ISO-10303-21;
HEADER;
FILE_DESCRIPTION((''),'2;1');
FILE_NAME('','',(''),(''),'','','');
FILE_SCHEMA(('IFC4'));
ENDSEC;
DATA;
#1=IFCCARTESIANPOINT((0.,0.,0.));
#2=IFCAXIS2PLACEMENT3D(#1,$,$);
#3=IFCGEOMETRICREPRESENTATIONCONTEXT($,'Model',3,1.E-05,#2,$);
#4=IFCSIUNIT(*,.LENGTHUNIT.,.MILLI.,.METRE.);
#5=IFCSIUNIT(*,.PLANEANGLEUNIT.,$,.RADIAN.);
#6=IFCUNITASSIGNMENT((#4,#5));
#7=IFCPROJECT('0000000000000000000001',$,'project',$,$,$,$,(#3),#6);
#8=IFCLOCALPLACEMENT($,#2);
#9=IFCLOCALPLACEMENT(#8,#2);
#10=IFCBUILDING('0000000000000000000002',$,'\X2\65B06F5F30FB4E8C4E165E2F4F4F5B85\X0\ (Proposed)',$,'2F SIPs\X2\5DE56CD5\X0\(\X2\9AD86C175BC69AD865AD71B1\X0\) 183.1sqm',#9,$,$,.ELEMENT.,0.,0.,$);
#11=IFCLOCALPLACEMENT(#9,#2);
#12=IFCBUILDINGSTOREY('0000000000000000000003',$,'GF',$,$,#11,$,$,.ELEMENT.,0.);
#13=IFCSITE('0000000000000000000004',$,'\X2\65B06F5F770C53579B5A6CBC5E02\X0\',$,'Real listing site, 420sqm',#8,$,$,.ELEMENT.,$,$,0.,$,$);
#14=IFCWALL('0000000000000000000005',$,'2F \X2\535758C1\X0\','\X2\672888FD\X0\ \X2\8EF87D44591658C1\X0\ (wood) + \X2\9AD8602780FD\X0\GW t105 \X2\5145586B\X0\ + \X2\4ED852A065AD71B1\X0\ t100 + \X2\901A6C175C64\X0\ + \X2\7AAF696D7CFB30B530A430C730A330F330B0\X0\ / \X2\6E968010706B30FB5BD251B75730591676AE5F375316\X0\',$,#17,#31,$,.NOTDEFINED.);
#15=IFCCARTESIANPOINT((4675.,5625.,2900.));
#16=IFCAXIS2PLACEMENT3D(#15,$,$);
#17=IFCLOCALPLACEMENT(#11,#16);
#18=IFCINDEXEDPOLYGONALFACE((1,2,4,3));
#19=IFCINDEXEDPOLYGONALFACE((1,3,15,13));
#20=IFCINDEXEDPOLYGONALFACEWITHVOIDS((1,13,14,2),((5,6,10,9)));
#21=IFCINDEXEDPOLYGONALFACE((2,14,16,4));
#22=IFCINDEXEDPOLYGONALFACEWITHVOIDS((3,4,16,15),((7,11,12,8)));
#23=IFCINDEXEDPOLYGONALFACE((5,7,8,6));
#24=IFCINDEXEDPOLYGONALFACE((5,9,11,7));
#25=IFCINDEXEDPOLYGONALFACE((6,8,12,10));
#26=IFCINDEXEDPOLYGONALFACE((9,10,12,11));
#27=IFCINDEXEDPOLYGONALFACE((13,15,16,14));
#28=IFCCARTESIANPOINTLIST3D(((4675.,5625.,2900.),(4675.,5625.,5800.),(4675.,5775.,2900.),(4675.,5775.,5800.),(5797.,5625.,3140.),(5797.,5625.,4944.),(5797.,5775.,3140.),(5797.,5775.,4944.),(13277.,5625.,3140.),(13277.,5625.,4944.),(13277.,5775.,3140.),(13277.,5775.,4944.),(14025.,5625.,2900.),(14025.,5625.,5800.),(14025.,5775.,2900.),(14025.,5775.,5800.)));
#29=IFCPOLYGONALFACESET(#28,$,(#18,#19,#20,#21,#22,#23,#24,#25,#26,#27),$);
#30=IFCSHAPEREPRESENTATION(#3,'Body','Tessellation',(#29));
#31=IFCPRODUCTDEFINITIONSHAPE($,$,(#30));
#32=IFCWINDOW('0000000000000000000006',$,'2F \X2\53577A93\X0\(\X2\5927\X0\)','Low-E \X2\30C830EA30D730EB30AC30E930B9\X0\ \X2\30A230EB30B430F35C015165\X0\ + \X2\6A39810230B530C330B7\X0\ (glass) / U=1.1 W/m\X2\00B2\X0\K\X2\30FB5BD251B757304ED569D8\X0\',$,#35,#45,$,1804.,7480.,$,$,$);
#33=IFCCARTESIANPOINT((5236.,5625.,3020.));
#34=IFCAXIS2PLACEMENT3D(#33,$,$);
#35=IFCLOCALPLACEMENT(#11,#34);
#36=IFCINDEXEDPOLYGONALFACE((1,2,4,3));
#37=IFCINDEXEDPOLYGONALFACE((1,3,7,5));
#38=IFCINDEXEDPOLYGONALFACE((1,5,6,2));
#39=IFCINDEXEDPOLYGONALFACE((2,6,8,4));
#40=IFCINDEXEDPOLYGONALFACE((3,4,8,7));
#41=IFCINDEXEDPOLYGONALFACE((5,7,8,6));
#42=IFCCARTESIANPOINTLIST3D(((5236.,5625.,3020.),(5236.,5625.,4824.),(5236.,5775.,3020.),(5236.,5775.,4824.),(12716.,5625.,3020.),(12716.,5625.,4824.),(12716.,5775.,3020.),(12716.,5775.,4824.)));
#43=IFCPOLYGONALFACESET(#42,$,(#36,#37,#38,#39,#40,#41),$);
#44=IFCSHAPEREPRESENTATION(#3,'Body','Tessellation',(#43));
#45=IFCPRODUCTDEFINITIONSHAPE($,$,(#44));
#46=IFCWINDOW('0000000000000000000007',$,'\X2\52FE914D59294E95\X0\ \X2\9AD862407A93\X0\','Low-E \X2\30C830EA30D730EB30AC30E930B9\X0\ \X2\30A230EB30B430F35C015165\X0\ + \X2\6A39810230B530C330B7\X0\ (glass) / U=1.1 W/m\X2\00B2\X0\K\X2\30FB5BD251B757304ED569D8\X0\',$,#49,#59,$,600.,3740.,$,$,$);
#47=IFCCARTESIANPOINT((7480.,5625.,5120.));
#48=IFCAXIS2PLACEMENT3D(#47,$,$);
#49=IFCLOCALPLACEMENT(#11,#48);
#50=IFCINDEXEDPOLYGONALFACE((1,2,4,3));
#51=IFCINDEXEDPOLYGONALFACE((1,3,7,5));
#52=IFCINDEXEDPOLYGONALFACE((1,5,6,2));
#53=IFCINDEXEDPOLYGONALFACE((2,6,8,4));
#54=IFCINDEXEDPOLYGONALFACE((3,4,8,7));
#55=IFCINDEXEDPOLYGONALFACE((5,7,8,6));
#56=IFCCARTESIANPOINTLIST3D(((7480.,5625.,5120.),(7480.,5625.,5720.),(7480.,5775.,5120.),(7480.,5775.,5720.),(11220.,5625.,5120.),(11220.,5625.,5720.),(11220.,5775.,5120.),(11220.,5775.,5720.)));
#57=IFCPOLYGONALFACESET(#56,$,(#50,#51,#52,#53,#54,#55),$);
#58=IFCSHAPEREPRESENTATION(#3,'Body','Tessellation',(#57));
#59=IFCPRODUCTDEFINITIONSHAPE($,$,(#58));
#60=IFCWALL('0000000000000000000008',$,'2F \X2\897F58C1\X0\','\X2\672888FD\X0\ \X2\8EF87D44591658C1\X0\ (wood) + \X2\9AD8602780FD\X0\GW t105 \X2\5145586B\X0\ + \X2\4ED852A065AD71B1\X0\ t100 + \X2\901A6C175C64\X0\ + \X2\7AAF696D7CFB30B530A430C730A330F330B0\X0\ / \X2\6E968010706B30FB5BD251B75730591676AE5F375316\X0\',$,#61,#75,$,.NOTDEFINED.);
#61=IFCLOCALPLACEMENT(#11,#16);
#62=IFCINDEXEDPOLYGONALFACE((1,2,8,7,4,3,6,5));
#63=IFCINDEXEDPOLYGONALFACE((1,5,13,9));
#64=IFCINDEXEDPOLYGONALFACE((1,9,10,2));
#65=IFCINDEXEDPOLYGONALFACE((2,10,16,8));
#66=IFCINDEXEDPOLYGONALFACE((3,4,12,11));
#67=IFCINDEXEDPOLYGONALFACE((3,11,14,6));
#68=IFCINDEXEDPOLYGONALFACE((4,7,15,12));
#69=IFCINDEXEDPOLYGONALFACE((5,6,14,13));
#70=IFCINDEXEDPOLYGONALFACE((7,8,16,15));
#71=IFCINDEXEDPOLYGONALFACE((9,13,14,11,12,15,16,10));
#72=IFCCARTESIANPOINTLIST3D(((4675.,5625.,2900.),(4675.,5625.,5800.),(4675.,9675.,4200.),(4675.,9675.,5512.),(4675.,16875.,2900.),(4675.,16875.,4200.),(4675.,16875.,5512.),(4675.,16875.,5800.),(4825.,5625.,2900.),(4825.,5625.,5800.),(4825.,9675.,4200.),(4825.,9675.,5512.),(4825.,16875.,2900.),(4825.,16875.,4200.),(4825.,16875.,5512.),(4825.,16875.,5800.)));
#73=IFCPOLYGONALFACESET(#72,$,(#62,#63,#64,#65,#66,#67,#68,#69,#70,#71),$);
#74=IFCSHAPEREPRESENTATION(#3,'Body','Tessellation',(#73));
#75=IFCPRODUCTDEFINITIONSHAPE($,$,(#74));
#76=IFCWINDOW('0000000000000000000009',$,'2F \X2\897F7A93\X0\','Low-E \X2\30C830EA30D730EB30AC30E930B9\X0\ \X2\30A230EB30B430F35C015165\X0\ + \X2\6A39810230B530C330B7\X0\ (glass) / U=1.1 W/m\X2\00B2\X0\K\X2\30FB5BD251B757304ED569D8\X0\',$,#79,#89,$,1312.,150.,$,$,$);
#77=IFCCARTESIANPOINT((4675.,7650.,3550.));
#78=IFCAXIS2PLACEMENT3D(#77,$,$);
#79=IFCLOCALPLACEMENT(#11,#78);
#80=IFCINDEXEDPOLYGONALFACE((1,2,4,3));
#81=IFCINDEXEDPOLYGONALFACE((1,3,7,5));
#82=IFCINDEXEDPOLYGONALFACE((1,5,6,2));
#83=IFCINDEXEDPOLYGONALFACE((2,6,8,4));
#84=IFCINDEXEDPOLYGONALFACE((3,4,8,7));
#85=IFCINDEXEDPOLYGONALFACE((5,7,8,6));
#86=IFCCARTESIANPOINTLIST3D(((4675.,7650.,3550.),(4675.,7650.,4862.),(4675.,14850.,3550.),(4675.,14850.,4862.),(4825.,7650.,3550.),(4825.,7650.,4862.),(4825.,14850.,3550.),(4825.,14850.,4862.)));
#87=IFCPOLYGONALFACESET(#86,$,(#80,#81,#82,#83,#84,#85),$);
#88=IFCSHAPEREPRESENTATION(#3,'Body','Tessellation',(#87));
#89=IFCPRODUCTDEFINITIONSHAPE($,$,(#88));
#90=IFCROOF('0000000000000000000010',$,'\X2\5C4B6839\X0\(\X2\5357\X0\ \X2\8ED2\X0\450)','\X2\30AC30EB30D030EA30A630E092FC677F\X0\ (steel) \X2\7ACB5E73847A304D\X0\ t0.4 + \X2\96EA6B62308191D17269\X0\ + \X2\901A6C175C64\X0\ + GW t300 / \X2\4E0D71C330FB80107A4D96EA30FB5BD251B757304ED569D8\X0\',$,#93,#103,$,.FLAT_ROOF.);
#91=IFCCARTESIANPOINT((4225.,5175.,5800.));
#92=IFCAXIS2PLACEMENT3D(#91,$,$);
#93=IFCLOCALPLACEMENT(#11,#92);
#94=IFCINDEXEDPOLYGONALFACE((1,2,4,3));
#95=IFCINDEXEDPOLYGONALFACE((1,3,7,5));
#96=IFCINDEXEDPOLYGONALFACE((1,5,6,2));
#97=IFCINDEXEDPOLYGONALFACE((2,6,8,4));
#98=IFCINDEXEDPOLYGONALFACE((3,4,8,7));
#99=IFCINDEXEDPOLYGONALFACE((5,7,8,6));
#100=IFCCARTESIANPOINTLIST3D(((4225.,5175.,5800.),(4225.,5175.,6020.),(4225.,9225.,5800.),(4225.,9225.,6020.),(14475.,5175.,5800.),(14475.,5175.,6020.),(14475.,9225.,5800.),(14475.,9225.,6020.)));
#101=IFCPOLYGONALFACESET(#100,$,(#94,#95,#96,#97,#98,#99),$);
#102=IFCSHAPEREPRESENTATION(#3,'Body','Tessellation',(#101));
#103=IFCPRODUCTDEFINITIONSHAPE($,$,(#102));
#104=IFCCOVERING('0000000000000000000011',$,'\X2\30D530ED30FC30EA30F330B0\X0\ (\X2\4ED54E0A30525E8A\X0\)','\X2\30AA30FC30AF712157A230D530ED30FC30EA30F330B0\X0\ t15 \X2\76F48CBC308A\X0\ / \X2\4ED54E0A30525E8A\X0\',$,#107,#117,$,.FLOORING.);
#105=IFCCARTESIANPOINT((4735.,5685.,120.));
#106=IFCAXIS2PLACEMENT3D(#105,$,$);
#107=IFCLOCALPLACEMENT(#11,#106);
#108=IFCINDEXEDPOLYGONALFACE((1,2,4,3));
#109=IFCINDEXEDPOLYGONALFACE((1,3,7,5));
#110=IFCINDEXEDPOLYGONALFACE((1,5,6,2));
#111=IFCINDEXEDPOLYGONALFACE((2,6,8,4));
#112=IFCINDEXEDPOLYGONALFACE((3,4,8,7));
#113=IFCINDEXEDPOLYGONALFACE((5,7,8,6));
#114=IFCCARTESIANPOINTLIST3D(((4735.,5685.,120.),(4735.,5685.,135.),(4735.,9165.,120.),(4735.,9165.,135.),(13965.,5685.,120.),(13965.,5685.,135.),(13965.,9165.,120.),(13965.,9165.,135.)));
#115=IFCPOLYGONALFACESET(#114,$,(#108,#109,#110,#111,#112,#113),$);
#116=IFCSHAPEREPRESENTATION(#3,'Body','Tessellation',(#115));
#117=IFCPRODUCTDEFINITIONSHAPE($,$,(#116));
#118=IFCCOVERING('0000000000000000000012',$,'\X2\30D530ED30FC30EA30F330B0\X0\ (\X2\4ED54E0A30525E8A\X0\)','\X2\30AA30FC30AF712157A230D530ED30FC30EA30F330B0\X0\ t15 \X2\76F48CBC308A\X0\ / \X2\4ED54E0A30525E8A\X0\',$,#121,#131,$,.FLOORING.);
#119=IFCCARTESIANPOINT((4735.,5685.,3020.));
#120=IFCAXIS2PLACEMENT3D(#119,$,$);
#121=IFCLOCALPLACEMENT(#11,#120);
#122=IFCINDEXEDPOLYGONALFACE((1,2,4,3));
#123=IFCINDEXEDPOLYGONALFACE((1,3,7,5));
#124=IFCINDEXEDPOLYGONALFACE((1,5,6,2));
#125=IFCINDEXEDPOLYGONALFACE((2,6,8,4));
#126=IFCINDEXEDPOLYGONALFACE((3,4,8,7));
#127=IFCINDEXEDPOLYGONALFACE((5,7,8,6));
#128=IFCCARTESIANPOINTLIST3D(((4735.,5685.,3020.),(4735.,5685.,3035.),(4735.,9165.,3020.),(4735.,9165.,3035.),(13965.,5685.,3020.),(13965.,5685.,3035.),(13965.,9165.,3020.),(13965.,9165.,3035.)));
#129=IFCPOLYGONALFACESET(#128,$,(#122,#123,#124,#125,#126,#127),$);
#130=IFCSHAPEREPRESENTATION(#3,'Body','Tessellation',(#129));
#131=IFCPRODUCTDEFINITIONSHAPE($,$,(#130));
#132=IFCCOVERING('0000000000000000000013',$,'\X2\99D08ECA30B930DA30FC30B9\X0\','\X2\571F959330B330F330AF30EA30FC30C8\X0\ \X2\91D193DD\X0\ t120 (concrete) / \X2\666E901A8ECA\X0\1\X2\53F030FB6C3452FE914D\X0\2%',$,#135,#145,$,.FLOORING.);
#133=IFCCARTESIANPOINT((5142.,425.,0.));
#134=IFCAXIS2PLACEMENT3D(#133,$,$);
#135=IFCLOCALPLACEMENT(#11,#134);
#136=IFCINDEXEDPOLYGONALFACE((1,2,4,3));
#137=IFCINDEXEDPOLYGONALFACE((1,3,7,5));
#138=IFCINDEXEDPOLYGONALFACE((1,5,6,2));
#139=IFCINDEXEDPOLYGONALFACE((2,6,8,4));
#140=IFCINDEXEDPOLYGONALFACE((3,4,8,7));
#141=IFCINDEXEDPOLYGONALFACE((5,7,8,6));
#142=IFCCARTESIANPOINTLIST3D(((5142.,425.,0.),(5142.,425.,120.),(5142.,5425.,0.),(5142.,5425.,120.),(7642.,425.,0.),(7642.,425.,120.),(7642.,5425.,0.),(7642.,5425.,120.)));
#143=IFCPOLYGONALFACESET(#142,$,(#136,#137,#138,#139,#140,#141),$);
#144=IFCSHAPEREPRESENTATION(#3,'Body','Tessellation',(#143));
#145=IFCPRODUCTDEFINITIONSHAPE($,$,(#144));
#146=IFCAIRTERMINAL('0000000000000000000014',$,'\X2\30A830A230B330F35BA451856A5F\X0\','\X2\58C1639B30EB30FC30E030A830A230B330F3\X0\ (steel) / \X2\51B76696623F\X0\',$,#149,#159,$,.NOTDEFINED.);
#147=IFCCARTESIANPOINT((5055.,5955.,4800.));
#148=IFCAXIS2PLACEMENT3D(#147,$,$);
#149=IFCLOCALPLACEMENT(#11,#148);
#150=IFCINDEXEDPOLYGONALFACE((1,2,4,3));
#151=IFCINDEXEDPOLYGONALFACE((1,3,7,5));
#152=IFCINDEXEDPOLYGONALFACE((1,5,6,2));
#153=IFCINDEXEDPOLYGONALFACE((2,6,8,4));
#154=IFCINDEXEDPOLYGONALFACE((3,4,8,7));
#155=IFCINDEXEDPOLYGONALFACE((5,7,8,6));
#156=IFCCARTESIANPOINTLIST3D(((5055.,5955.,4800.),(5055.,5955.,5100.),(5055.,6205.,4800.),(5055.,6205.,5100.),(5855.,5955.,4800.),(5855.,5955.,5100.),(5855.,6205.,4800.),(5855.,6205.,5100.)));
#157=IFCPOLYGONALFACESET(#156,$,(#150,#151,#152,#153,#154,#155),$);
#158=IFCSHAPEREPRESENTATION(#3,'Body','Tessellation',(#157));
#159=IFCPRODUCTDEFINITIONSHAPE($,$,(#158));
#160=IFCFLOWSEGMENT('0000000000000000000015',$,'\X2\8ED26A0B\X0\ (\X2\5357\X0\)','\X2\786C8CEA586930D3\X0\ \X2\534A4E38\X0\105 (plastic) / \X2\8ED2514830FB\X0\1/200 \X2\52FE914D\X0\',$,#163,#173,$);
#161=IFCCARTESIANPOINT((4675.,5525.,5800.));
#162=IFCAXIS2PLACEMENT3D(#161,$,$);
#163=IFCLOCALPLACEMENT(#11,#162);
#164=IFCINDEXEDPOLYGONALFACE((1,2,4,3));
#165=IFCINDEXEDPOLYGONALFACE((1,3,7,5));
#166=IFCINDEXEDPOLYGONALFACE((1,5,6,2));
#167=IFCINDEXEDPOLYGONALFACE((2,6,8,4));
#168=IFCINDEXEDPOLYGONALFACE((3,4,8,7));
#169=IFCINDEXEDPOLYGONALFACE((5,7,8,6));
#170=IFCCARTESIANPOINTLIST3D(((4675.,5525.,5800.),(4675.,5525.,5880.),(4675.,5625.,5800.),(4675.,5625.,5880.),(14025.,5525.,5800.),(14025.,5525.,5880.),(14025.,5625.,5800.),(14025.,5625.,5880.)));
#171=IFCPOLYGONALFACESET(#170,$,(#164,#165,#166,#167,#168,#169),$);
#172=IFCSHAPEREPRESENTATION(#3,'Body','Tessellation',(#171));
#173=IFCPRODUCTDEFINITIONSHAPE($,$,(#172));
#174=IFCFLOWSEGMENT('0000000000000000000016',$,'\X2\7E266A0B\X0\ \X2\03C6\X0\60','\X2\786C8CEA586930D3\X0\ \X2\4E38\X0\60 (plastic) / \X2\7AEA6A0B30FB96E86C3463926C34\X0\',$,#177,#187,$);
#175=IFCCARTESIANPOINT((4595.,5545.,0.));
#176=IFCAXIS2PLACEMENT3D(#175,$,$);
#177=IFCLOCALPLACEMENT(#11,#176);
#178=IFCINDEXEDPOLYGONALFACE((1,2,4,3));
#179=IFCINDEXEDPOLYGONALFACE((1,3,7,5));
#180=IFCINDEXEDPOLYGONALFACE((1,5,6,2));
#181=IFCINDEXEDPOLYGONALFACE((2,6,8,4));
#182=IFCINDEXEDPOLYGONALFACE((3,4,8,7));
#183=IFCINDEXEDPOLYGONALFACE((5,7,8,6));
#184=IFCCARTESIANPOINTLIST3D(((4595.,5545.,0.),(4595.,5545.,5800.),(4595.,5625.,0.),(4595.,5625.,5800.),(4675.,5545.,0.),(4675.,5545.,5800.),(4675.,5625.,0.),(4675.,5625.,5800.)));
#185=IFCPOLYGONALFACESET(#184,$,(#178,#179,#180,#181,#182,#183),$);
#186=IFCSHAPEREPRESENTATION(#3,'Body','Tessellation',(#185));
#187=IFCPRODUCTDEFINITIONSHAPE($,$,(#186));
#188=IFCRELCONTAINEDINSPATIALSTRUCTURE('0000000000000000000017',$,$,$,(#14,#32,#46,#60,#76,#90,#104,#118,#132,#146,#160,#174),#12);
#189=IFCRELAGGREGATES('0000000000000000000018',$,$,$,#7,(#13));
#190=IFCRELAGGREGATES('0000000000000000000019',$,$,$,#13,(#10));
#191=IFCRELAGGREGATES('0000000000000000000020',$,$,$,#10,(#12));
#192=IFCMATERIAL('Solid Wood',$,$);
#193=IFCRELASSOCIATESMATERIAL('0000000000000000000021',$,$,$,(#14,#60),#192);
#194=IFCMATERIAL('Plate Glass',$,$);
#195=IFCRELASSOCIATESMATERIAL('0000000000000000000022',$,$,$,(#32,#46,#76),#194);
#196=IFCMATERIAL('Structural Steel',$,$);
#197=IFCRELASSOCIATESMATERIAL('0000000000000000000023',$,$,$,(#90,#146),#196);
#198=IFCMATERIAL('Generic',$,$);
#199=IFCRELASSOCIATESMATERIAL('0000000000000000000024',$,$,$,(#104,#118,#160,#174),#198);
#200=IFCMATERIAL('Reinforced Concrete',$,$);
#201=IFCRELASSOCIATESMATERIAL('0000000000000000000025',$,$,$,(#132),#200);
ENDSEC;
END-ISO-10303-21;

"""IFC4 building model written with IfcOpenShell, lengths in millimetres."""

from ifc_helpers import new_model, si_unit, frame, frame_2d, origin, place, context, project, spatial, rectangle, extrude, material, element, fill, save


model = new_model("IFC4")

# Units and contexts
model_context = context("Model", 3, precision=1e-05, world=origin())
ifc_project = project(units=[si_unit("LENGTHUNIT", "METRE", prefix="MILLI"), si_unit("PLANEANGLEUNIT", "RADIAN")], contexts=[model_context])

# Site, building, storey
site_placement = place(None, origin())
site = spatial("IfcSite", under=ifc_project, at=site_placement, Name="新潟県南魚沼市", ObjectType="Real listing site, 420sqm", CompositionType="ELEMENT", RefElevation=0.0)
building_placement = place(site_placement, origin())
building = spatial("IfcBuilding", under=site, at=building_placement, Name="新潟・二世帯住宅 (Proposed)", ObjectType="2F SIPs工法(高気密高断熱) 183.1sqm", CompositionType="ELEMENT", ElevationOfRefHeight=0.0, ElevationOfTerrain=0.0)
storey_placement = place(building_placement, origin())
storey = spatial("IfcBuildingStorey", under=building, at=storey_placement, Name="GF", CompositionType="ELEMENT", Elevation=0.0)

# Shared definitions
ifc_material_1 = material(Name="Solid Wood")

# Shared definitions
ifc_material_2 = material(Name="Reinforced Concrete")

# Shared definitions
ifc_material_3 = material(Name="Plate Glass")

# Wall, openings, windows
wall_1_placement = place(storey_placement, frame((4675.0, 5625.0, 2900.0)))
wall_1 = element("IfcWall", 1, at=wall_1_placement, inside=storey, material=ifc_material_1, Name="2F 南壁", Description="木製 軸組外壁 (wood) + 高性能GW t105 充填 + 付加断熱 t100 + 通気層 + 窯業系サイディング / 準耐火・寒冷地外皮強化", PredefinedType="NOTDEFINED", context=model_context, shape_type="SweptSolid", body=[
    extrude(rectangle(XDim=9350.0, YDim=150.0, at=frame_2d((4675.0, 75.0))), frame((4675.0, 5625.0, 2900.0)), (0.0, 0.0, 1.0), 2900.0),
])
opening_1_placement = place(storey_placement, frame((5236.0, 5625.0, 3020.0)))
opening_1 = element("IfcOpeningElement", 2, at=opening_1_placement, cuts=wall_1, PredefinedType="NOTDEFINED", context=model_context, shape_type="SweptSolid", body=[
    extrude(rectangle(XDim=7480.0, YDim=150.0, at=frame_2d((3740.0, 75.0))), frame((5236.0, 5625.0, 3020.0)), (0.0, 0.0, 1.0), 1804.0),
])
opening_2_placement = place(storey_placement, frame((7480.0, 5625.0, 5120.0)))
opening_2 = element("IfcOpeningElement", 3, at=opening_2_placement, cuts=wall_1, PredefinedType="NOTDEFINED", context=model_context, shape_type="SweptSolid", body=[
    extrude(rectangle(XDim=3740.0, YDim=150.0, at=frame_2d((1870.0, 75.0))), frame((7480.0, 5625.0, 5120.0)), (0.0, 0.0, 1.0), 600.0),
])
window_1_placement = place(storey_placement, frame((5236.0, 5625.0, 3020.0)))
window_1 = element("IfcWindow", 4, at=window_1_placement, inside=storey, material=ifc_material_3, Name="2F 南窓(大)", Description="Low-E トリプルガラス アルゴン封入 + 樹脂サッシ (glass) / U=1.1 W/m²K・寒冷地仕様", OverallHeight=1804.0, OverallWidth=7480.0, context=model_context, shape_type="SweptSolid", body=[
    extrude(rectangle(XDim=7480.0, YDim=150.0, at=frame_2d((3740.0, 75.0))), frame((5236.0, 5625.0, 3020.0)), (0.0, 0.0, 1.0), 1804.0),
])
fill(opening_1, window_1)
window_2_placement = place(storey_placement, frame((7480.0, 5625.0, 5120.0)))
window_2 = element("IfcWindow", 5, at=window_2_placement, inside=storey, material=ifc_material_3, Name="勾配天井 高所窓", Description="Low-E トリプルガラス アルゴン封入 + 樹脂サッシ (glass) / U=1.1 W/m²K・寒冷地仕様", OverallHeight=600.0, OverallWidth=3740.0, context=model_context, shape_type="SweptSolid", body=[
    extrude(rectangle(XDim=3740.0, YDim=150.0, at=frame_2d((1870.0, 75.0))), frame((7480.0, 5625.0, 5120.0)), (0.0, 0.0, 1.0), 600.0),
])
fill(opening_2, window_2)

# Wall, opening, window
wall_2_placement = place(storey_placement, frame((4675.0, 5625.0, 2900.0)))
wall_2 = element("IfcWall", 6, at=wall_2_placement, inside=storey, material=ifc_material_1, Name="2F 西壁", Description="木製 軸組外壁 (wood) + 高性能GW t105 充填 + 付加断熱 t100 + 通気層 + 窯業系サイディング / 準耐火・寒冷地外皮強化", PredefinedType="NOTDEFINED", context=model_context, shape_type="SweptSolid", body=[
    extrude(rectangle(XDim=150.0, YDim=11250.0, at=frame_2d((75.0, 5625.0))), frame((4675.0, 5625.0, 2900.0)), (0.0, 0.0, 1.0), 2900.0),
])
opening_3_placement = place(storey_placement, frame((4675.0, 7650.0, 3550.0)))
opening_3 = element("IfcOpeningElement", 7, at=opening_3_placement, cuts=wall_2, PredefinedType="NOTDEFINED", context=model_context, shape_type="SweptSolid", body=[
    extrude(rectangle(XDim=150.0, YDim=7200.0, at=frame_2d((75.0, 3600.0))), frame((4675.0, 7650.0, 3550.0)), (0.0, 0.0, 1.0), 1312.0),
])
window_3_placement = place(storey_placement, frame((4675.0, 7650.0, 3550.0)))
window_3 = element("IfcWindow", 8, at=window_3_placement, inside=storey, material=ifc_material_3, Name="2F 西窓", Description="Low-E トリプルガラス アルゴン封入 + 樹脂サッシ (glass) / U=1.1 W/m²K・寒冷地仕様", OverallHeight=1312.0, OverallWidth=150.0, context=model_context, shape_type="SweptSolid", body=[
    extrude(rectangle(XDim=150.0, YDim=7200.0, at=frame_2d((75.0, 3600.0))), frame((4675.0, 7650.0, 3550.0)), (0.0, 0.0, 1.0), 1312.0),
])
fill(opening_3, window_3)

# Roof
ifc_material_4 = material(Name="Structural Steel")
for number, where, name in (
    (9, (4225.0, 5175.0, 5800.0), "屋根(南 軒450)"),
):
    element("IfcRoof", number, at=place(storey_placement, frame(where)), inside=storey, material=ifc_material_4, Name=name, Description="ガルバリウム鋼板 (steel) 立平葺き t0.4 + 雪止め金物 + 通気層 + GW t300 / 不燃・耐積雪・寒冷地仕様", PredefinedType="FLAT_ROOF", context=model_context, shape_type="SweptSolid", body=[
        extrude(rectangle(XDim=10250.0, YDim=4050.0, at=frame_2d((5125.0, 2025.0))), frame((4225.0, 5175.0, 5800.0)), (0.0, 0.0, 1.0), 220.0),
    ])

# Coverings
ifc_material_5 = material(Name="Generic")
covering_1_placement = place(storey_placement, frame((4735.0, 5685.0, 120.0)))
element("IfcCovering", 10, at=covering_1_placement, inside=storey, material=ifc_material_5, Name="フローリング (仕上げ床)", Description="オーク無垢フローリング t15 直貼り / 仕上げ床", PredefinedType="FLOORING", context=model_context, shape_type="SweptSolid", body=[
    extrude(rectangle(XDim=9230.0, YDim=3480.0, at=frame_2d((4615.0, 1740.0))), frame((4735.0, 5685.0, 120.0)), (0.0, 0.0, 1.0), 15.0),
])
covering_2_placement = place(storey_placement, frame((4735.0, 5685.0, 3020.0)))
element("IfcCovering", 11, at=covering_2_placement, inside=storey, material=ifc_material_5, Name="フローリング (仕上げ床)", Description="オーク無垢フローリング t15 直貼り / 仕上げ床", PredefinedType="FLOORING", context=model_context, shape_type="SweptSolid", body=[
    extrude(rectangle(XDim=9230.0, YDim=3480.0, at=frame_2d((4615.0, 1740.0))), frame((4735.0, 5685.0, 3020.0)), (0.0, 0.0, 1.0), 15.0),
])
covering_3_placement = place(storey_placement, frame((5142.0, 425.0, 0.0)))
element("IfcCovering", 12, at=covering_3_placement, inside=storey, material=ifc_material_2, Name="駐車スペース", Description="土間コンクリート 金鏝 t120 (concrete) / 普通車1台・水勾配2%", PredefinedType="FLOORING", context=model_context, shape_type="SweptSolid", body=[
    extrude(rectangle(XDim=2500.0, YDim=5000.0, at=frame_2d((1250.0, 2500.0))), frame((5142.0, 425.0, 0.0)), (0.0, 0.0, 1.0), 120.0),
])

# Air terminal
air_terminal_placement = place(storey_placement, frame((5055.0, 5955.0, 4800.0)))
element("IfcAirTerminal", 13, at=air_terminal_placement, inside=storey, material=ifc_material_4, Name="エアコン室内機", Description="壁掛ルームエアコン (steel) / 冷暖房", PredefinedType="NOTDEFINED", context=model_context, shape_type="SweptSolid", body=[
    extrude(rectangle(XDim=800.0, YDim=250.0, at=frame_2d((400.0, 125.0))), frame((5055.0, 5955.0, 4800.0)), (0.0, 0.0, 1.0), 300.0),
])

# Flow segments
flow_segment_1_placement = place(storey_placement, frame((4675.0, 5525.0, 5800.0)))
element("IfcFlowSegment", 14, at=flow_segment_1_placement, inside=storey, material=ifc_material_5, Name="軒樋 (南)", Description="硬質塩ビ 半丸105 (plastic) / 軒先・1/200 勾配", context=model_context, shape_type="SweptSolid", body=[
    extrude(rectangle(XDim=9350.0, YDim=100.0, at=frame_2d((4675.0, 50.0))), frame((4675.0, 5525.0, 5800.0)), (0.0, 0.0, 1.0), 80.0),
])
flow_segment_2_placement = place(storey_placement, frame((4595.0, 5545.0, 0.0)))
element("IfcFlowSegment", 15, at=flow_segment_2_placement, inside=storey, material=ifc_material_5, Name="縦樋 φ60", Description="硬質塩ビ 丸60 (plastic) / 竪樋・雨水排水", context=model_context, shape_type="SweptSolid", body=[
    extrude(rectangle(XDim=80.0, YDim=80.0, at=frame_2d((40.0, 40.0))), frame((4595.0, 5545.0, 0.0)), (0.0, 0.0, 1.0), 5800.0),
])

save(model, "model.ifc")
